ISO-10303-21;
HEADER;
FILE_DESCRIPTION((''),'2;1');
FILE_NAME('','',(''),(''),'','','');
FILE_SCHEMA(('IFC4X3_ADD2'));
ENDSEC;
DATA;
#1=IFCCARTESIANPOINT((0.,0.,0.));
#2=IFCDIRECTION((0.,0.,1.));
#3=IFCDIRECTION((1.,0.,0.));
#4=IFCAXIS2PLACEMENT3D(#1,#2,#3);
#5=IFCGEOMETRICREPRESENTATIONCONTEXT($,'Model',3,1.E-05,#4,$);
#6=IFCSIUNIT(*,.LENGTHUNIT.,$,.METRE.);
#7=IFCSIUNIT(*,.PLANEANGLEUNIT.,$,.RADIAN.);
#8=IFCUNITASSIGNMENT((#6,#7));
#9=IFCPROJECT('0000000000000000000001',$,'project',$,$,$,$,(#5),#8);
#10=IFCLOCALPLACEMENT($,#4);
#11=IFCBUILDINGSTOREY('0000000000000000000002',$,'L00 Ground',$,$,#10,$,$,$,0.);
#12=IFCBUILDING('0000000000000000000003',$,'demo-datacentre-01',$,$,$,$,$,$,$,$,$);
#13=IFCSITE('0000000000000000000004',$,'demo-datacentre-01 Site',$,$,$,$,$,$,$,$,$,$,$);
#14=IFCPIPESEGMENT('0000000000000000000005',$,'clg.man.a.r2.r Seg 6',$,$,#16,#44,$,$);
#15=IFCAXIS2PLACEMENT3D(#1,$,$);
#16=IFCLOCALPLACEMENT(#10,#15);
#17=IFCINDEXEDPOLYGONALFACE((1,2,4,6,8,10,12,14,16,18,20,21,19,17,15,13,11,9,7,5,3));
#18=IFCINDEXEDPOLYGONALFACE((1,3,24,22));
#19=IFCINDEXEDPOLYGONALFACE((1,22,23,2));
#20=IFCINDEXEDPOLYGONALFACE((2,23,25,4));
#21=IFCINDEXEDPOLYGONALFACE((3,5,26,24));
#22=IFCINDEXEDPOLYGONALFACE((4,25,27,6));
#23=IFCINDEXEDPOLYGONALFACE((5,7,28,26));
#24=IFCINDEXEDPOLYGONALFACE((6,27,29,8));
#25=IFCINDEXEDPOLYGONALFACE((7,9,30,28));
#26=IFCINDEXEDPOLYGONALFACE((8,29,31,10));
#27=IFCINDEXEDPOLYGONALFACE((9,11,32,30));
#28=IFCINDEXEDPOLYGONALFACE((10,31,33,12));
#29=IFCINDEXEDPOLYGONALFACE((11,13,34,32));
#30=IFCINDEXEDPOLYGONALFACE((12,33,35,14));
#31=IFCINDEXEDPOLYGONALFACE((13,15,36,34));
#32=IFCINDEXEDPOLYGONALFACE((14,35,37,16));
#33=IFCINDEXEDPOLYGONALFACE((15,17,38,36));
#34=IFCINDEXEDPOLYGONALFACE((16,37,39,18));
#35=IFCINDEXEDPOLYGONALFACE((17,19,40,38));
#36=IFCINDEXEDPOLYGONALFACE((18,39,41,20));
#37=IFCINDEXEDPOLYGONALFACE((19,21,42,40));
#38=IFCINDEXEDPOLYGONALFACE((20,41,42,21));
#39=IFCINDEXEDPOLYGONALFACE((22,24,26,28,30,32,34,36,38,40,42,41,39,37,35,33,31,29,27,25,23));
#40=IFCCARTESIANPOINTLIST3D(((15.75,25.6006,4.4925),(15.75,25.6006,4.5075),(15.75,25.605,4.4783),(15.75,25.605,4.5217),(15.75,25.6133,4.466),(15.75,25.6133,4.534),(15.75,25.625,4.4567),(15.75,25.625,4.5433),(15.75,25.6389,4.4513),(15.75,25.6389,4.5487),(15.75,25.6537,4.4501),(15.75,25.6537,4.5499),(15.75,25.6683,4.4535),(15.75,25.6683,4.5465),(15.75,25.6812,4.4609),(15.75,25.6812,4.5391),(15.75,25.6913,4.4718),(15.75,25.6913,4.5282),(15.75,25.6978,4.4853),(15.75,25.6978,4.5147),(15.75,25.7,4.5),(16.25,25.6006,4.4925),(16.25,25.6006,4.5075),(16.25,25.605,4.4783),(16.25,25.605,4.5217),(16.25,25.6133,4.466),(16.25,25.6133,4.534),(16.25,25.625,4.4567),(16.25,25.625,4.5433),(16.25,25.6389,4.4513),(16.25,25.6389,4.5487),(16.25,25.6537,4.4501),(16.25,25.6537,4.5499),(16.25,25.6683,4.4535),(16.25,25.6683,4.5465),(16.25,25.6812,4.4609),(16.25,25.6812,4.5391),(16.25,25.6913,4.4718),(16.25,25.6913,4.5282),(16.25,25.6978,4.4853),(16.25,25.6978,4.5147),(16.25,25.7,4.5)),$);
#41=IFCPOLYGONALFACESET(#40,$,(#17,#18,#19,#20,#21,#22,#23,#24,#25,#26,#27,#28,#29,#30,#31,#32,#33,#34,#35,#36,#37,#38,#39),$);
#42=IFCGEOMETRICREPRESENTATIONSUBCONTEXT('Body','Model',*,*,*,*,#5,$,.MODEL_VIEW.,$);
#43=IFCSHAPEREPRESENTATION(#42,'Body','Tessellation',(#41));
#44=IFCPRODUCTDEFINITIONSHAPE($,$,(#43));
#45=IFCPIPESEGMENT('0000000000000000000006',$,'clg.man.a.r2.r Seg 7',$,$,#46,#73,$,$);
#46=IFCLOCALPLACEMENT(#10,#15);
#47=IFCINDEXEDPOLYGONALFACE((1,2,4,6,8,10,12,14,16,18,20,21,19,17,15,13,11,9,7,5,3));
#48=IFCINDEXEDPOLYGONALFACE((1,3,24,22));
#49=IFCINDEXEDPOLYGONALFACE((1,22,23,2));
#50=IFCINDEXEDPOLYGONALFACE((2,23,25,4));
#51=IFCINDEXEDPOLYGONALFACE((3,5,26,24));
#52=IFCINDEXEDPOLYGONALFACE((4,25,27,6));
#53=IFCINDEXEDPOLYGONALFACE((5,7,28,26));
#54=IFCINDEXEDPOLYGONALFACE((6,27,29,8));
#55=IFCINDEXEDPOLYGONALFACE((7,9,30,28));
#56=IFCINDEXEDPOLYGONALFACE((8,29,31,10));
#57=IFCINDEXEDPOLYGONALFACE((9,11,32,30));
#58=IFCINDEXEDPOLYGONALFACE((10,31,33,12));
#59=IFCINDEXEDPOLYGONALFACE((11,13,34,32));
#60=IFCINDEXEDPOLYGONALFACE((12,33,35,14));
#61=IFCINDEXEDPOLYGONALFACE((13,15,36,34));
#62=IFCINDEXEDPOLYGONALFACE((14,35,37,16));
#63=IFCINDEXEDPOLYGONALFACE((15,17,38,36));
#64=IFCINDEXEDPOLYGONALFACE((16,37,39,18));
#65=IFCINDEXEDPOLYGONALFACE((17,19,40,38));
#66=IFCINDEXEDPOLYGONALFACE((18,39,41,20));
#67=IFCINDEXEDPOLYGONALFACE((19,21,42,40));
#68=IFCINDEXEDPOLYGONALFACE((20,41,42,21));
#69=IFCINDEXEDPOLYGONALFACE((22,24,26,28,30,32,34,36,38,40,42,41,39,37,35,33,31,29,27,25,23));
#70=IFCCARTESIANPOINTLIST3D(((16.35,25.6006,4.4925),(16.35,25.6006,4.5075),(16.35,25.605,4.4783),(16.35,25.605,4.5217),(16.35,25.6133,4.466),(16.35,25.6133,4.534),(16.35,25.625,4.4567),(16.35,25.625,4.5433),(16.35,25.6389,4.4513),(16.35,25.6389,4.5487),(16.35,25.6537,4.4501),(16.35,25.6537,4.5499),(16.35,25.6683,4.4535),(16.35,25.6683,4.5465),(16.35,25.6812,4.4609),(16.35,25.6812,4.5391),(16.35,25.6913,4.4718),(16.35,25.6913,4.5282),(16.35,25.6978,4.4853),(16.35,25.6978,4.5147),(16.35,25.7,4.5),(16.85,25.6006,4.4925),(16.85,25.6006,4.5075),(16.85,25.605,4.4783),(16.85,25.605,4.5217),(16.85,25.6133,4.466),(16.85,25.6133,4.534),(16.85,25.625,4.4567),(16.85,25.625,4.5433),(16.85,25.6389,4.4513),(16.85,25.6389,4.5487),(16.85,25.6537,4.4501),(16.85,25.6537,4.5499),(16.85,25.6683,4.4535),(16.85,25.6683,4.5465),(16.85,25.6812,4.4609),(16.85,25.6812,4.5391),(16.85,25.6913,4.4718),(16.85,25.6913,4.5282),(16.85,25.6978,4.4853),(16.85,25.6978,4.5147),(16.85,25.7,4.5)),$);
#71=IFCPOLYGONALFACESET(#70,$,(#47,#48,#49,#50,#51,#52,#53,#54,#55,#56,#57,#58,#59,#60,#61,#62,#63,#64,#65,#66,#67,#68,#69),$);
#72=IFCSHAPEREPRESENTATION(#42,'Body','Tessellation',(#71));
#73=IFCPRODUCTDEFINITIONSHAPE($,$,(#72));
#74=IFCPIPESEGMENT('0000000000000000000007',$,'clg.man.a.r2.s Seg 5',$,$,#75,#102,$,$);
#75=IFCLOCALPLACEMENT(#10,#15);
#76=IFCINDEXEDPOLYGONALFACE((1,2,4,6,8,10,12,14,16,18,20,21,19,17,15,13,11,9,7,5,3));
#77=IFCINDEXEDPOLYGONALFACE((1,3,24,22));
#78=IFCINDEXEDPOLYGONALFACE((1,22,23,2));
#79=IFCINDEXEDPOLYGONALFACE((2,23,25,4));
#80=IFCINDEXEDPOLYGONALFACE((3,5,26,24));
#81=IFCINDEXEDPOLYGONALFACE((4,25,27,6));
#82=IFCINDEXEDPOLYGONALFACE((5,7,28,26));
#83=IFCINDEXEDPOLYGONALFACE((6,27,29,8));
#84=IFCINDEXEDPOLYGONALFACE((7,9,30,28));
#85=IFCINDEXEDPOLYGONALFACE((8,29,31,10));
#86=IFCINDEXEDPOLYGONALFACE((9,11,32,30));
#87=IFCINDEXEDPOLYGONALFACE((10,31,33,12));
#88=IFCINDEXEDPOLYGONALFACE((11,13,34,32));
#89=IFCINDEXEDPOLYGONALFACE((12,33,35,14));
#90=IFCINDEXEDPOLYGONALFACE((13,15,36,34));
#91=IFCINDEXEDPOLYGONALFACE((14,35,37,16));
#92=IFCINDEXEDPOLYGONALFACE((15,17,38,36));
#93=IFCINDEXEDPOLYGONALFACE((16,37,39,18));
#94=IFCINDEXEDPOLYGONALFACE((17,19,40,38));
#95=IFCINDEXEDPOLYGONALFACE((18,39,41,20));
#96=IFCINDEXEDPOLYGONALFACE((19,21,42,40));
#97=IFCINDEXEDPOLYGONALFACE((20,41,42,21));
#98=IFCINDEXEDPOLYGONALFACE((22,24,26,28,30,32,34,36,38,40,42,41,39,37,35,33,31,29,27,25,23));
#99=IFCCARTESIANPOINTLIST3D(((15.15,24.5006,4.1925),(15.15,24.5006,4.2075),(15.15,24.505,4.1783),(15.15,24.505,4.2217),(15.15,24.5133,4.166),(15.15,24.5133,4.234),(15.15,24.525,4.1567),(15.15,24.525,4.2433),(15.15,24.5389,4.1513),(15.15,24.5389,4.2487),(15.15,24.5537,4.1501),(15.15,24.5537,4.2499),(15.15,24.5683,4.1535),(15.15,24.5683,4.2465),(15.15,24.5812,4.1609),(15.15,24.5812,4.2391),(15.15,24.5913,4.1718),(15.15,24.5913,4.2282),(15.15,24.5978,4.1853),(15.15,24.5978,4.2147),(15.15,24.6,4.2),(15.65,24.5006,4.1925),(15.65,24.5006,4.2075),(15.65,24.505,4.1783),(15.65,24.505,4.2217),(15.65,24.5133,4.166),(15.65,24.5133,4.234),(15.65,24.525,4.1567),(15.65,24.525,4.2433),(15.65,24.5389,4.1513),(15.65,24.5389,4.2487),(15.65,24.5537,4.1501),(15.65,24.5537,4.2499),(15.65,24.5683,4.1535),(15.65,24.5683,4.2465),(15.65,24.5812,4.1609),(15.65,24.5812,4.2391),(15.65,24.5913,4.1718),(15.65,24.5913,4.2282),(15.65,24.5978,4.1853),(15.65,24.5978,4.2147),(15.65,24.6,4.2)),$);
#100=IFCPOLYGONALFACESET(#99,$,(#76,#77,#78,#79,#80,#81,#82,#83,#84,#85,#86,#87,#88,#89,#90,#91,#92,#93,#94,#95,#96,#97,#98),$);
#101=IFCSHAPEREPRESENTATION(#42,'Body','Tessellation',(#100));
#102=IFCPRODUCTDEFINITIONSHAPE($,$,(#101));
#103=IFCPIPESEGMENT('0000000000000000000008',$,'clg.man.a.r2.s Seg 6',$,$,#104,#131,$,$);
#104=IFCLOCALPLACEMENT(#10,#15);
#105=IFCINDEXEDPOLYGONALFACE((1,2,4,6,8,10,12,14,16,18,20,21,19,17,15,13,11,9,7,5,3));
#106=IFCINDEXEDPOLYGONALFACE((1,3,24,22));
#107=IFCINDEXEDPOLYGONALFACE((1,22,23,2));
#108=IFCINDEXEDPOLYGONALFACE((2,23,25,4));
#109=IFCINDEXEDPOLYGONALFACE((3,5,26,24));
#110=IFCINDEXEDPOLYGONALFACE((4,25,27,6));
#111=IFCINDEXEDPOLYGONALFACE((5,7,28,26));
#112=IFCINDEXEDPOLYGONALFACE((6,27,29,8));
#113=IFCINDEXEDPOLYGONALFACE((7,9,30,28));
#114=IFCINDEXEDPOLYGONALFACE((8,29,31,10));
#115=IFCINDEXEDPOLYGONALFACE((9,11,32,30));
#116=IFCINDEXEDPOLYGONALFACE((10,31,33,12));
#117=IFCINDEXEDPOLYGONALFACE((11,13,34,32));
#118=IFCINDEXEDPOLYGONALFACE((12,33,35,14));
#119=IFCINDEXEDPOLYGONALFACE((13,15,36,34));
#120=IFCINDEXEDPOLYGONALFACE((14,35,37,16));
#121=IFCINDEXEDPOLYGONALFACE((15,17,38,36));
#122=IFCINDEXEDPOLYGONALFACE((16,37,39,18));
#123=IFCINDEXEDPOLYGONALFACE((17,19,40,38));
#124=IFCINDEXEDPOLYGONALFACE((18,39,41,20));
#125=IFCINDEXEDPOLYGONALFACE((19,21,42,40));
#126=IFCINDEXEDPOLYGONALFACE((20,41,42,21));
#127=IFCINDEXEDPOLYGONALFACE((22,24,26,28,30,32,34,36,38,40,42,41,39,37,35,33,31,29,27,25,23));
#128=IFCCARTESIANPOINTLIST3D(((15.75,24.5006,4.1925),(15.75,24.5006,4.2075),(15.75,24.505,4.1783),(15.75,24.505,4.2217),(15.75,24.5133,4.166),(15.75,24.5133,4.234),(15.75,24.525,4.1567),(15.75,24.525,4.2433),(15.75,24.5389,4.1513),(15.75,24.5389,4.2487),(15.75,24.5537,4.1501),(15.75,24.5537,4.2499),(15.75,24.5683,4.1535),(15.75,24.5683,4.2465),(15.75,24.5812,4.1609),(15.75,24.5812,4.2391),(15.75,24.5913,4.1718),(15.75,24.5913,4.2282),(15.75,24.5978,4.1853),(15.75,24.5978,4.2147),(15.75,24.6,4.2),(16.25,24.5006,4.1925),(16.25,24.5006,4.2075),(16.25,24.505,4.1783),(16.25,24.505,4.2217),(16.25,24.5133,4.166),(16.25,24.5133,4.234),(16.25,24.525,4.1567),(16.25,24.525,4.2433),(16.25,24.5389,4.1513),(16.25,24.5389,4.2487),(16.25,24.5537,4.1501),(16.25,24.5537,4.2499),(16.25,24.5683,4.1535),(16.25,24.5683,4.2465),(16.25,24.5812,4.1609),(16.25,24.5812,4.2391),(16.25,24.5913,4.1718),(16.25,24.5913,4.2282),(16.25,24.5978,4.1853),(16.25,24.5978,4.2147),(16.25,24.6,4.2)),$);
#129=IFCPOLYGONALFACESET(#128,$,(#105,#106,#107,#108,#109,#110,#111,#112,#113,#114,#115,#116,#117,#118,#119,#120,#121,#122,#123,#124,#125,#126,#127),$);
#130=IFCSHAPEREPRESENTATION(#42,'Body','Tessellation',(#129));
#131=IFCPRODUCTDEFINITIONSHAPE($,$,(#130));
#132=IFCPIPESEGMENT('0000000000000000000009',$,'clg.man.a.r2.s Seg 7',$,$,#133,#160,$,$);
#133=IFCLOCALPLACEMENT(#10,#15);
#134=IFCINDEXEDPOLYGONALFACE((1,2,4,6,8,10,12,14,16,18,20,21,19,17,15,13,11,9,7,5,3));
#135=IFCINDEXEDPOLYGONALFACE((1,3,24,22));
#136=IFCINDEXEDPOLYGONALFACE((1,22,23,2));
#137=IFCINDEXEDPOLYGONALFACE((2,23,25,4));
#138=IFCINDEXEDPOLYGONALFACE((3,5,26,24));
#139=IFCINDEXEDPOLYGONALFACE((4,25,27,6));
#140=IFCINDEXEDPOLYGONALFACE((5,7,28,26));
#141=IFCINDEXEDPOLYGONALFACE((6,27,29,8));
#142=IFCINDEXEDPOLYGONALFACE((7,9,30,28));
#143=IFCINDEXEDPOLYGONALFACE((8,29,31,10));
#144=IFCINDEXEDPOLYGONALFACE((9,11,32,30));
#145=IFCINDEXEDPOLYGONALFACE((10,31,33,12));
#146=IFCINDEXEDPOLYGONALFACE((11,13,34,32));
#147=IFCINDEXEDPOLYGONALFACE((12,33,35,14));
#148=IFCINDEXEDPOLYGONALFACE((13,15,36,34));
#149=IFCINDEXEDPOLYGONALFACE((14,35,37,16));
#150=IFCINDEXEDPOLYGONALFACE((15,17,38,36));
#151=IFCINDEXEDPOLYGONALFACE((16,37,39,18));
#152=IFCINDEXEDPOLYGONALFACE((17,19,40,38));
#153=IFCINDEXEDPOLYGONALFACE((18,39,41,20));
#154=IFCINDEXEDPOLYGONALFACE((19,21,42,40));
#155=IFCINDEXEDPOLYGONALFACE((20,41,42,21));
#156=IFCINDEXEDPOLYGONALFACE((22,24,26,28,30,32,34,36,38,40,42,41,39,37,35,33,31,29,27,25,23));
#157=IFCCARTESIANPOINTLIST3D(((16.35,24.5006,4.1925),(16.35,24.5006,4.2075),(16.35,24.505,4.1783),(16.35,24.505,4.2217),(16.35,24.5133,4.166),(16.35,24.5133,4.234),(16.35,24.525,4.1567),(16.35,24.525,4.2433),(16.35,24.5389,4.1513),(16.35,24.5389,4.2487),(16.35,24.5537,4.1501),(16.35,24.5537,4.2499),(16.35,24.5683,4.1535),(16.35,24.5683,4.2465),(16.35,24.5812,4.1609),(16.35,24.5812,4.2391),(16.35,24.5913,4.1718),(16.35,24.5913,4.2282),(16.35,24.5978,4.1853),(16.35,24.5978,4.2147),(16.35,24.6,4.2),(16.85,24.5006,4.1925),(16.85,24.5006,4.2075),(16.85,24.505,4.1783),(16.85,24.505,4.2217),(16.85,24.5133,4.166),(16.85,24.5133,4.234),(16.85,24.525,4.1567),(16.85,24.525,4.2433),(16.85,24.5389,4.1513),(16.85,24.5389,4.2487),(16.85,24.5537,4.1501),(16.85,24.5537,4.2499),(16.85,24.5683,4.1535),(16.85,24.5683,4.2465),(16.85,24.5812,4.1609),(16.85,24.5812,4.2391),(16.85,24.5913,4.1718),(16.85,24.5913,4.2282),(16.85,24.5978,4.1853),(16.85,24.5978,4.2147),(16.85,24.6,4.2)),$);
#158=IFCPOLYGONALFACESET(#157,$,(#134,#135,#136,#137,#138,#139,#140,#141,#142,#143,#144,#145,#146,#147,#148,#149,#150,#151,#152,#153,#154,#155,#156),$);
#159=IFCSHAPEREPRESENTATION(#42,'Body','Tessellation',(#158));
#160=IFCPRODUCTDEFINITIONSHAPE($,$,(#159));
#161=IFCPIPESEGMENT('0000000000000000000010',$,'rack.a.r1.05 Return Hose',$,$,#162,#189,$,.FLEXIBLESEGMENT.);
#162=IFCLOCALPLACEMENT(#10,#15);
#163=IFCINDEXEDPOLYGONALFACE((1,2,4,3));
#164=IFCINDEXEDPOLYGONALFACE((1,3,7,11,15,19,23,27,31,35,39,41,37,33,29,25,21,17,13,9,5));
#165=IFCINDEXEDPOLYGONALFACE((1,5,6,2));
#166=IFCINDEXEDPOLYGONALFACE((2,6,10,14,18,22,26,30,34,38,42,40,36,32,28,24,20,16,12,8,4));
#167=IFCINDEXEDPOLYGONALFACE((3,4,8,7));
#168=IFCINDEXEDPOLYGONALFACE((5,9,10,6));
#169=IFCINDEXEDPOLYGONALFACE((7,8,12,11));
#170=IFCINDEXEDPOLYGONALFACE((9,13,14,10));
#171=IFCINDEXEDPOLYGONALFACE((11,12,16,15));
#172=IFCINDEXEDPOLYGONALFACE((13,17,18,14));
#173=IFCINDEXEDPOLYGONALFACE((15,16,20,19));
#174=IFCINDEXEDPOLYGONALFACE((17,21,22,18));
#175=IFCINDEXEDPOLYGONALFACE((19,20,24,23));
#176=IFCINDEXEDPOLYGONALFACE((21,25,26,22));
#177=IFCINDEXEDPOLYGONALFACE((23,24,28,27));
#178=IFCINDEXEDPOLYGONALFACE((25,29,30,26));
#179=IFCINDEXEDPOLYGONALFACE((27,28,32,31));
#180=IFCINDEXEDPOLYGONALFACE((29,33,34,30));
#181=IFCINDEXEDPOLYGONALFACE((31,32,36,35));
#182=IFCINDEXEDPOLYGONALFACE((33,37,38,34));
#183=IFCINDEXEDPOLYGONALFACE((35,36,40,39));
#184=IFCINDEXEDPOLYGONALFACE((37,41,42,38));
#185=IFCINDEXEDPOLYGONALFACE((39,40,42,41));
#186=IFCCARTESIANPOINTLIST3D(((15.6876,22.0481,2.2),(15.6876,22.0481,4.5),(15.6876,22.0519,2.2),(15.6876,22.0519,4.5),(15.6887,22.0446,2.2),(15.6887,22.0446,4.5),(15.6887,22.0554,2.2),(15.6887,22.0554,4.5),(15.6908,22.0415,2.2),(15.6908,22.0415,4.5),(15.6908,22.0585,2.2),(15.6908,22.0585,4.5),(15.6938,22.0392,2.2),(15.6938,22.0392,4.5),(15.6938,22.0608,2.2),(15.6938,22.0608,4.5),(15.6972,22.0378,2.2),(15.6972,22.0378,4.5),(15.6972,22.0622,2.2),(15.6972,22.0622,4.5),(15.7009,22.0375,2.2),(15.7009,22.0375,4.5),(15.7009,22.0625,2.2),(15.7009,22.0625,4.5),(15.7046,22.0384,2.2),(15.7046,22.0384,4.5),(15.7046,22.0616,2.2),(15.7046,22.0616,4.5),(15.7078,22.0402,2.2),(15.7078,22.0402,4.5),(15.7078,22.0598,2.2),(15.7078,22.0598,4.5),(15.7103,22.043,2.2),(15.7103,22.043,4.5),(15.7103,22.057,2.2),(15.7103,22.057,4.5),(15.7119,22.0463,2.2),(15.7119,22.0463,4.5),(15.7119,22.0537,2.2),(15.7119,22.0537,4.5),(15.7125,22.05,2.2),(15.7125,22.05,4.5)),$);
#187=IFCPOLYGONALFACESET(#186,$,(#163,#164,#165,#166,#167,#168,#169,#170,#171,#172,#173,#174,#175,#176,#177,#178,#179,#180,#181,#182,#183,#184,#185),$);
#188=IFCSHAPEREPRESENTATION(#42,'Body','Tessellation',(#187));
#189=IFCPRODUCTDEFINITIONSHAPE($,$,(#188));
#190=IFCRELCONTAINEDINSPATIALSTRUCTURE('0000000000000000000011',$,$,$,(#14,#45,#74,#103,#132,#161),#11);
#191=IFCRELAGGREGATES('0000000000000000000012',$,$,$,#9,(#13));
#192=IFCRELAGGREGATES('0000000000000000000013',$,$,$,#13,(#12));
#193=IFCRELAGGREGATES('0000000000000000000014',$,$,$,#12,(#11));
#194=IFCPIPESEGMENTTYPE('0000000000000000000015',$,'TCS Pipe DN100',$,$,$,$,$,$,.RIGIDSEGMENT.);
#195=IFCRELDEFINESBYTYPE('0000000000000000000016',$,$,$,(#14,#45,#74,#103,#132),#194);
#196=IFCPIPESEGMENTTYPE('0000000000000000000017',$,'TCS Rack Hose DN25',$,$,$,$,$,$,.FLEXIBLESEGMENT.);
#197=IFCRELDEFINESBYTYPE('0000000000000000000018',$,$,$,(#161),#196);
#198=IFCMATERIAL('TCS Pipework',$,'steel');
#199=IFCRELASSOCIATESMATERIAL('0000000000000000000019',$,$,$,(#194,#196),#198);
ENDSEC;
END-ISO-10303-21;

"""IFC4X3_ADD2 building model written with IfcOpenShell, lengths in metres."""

from ifc_helpers import new_model, si_unit, frame, origin_with_axes, place, context, subcontext, project, spatial, circle, extrude, material, type_object, element, save


model = new_model("IFC4X3_ADD2")

# Units and contexts
model_context = context("Model", 3, precision=1e-05, world=origin_with_axes())
body_context = subcontext(model_context, "Body", "Model", "MODEL_VIEW")
ifc_project = project(units=[si_unit("LENGTHUNIT", "METRE"), si_unit("PLANEANGLEUNIT", "RADIAN")], contexts=[model_context])

# Site, building, storey
site = spatial("IfcSite", under=ifc_project, Name="demo-datacentre-01 Site")
building = spatial("IfcBuilding", under=site, Name="demo-datacentre-01")
storey_placement = place(None, origin_with_axes())
storey = spatial("IfcBuildingStorey", under=building, at=storey_placement, Name="L00 Ground", Elevation=0.0)

# Shared definitions
ifc_material = material(Name="TCS Pipework", Category="steel")

# Pipe segments
pipe_segment_type_1 = type_object("IfcPipeSegmentType", Name="TCS Pipe DN100", PredefinedType="RIGIDSEGMENT", material=ifc_material)
for number, where, z_axis, x_axis, name in (
    (1, (15.75, 25.65, 4.5), (1.0, 0.0, 0.0), (0.0, 1.0, 0.0), "clg.man.a.r2.r Seg 6"),
):
    element("IfcPipeSegment", number, at=place(storey_placement, frame(where, z_axis=z_axis, x_axis=x_axis)), inside=storey, type_object=pipe_segment_type_1, Name=name, context=body_context, shape_type="SweptSolid", body=[
        extrude(circle(Radius=0.05), origin_with_axes(), (0.0, 0.0, 1.0), 0.5),
    ])
pipe_segment_1_placement = place(storey_placement, frame((16.35, 25.65, 4.5), z_axis=(1.0, 0.0, 0.0), x_axis=(0.0, 1.0, 0.0)))
element("IfcPipeSegment", 2, at=pipe_segment_1_placement, inside=storey, type_object=pipe_segment_type_1, Name="clg.man.a.r2.r Seg 7", context=body_context, shape_type="SweptSolid", body=[
    extrude(circle(Radius=0.05), origin_with_axes(), (0.0, 0.0, 1.0), 0.5),
])
for number, where, z_axis, x_axis, name in (
    (3, (15.15, 24.55, 4.2), (1.0, 0.0, 0.0), (0.0, 1.0, 0.0), "clg.man.a.r2.s Seg 5"),
    (4, (15.75, 24.55, 4.2), (1.0, 0.0, 0.0), (0.0, 1.0, 0.0), "clg.man.a.r2.s Seg 6"),
):
    element("IfcPipeSegment", number, at=place(storey_placement, frame(where, z_axis=z_axis, x_axis=x_axis)), inside=storey, type_object=pipe_segment_type_1, Name=name, context=body_context, shape_type="SweptSolid", body=[
        extrude(circle(Radius=0.05), origin_with_axes(), (0.0, 0.0, 1.0), 0.5),
    ])
pipe_segment_2_placement = place(storey_placement, frame((16.35, 24.55, 4.2), z_axis=(1.0, 0.0, 0.0), x_axis=(0.0, 1.0, 0.0)))
element("IfcPipeSegment", 5, at=pipe_segment_2_placement, inside=storey, type_object=pipe_segment_type_1, Name="clg.man.a.r2.s Seg 7", context=body_context, shape_type="SweptSolid", body=[
    extrude(circle(Radius=0.05), origin_with_axes(), (0.0, 0.0, 1.0), 0.5),
])
pipe_segment_type_2 = type_object("IfcPipeSegmentType", Name="TCS Rack Hose DN25", PredefinedType="FLEXIBLESEGMENT", material=ifc_material)
for number, where, z_axis, x_axis, name in (
    (6, (15.7, 22.05, 4.5), (0.0, 0.0, -1.0), (1.0, 0.0, 0.0), "rack.a.r1.05 Return Hose"),
):
    element("IfcPipeSegment", number, at=place(storey_placement, frame(where, z_axis=z_axis, x_axis=x_axis)), inside=storey, type_object=pipe_segment_type_2, Name=name, PredefinedType="FLEXIBLESEGMENT", context=body_context, shape_type="SweptSolid", body=[
        extrude(circle(Radius=0.0125), origin_with_axes(), (0.0, 0.0, 1.0), 2.3),
    ])

save(model, "model.ifc")
